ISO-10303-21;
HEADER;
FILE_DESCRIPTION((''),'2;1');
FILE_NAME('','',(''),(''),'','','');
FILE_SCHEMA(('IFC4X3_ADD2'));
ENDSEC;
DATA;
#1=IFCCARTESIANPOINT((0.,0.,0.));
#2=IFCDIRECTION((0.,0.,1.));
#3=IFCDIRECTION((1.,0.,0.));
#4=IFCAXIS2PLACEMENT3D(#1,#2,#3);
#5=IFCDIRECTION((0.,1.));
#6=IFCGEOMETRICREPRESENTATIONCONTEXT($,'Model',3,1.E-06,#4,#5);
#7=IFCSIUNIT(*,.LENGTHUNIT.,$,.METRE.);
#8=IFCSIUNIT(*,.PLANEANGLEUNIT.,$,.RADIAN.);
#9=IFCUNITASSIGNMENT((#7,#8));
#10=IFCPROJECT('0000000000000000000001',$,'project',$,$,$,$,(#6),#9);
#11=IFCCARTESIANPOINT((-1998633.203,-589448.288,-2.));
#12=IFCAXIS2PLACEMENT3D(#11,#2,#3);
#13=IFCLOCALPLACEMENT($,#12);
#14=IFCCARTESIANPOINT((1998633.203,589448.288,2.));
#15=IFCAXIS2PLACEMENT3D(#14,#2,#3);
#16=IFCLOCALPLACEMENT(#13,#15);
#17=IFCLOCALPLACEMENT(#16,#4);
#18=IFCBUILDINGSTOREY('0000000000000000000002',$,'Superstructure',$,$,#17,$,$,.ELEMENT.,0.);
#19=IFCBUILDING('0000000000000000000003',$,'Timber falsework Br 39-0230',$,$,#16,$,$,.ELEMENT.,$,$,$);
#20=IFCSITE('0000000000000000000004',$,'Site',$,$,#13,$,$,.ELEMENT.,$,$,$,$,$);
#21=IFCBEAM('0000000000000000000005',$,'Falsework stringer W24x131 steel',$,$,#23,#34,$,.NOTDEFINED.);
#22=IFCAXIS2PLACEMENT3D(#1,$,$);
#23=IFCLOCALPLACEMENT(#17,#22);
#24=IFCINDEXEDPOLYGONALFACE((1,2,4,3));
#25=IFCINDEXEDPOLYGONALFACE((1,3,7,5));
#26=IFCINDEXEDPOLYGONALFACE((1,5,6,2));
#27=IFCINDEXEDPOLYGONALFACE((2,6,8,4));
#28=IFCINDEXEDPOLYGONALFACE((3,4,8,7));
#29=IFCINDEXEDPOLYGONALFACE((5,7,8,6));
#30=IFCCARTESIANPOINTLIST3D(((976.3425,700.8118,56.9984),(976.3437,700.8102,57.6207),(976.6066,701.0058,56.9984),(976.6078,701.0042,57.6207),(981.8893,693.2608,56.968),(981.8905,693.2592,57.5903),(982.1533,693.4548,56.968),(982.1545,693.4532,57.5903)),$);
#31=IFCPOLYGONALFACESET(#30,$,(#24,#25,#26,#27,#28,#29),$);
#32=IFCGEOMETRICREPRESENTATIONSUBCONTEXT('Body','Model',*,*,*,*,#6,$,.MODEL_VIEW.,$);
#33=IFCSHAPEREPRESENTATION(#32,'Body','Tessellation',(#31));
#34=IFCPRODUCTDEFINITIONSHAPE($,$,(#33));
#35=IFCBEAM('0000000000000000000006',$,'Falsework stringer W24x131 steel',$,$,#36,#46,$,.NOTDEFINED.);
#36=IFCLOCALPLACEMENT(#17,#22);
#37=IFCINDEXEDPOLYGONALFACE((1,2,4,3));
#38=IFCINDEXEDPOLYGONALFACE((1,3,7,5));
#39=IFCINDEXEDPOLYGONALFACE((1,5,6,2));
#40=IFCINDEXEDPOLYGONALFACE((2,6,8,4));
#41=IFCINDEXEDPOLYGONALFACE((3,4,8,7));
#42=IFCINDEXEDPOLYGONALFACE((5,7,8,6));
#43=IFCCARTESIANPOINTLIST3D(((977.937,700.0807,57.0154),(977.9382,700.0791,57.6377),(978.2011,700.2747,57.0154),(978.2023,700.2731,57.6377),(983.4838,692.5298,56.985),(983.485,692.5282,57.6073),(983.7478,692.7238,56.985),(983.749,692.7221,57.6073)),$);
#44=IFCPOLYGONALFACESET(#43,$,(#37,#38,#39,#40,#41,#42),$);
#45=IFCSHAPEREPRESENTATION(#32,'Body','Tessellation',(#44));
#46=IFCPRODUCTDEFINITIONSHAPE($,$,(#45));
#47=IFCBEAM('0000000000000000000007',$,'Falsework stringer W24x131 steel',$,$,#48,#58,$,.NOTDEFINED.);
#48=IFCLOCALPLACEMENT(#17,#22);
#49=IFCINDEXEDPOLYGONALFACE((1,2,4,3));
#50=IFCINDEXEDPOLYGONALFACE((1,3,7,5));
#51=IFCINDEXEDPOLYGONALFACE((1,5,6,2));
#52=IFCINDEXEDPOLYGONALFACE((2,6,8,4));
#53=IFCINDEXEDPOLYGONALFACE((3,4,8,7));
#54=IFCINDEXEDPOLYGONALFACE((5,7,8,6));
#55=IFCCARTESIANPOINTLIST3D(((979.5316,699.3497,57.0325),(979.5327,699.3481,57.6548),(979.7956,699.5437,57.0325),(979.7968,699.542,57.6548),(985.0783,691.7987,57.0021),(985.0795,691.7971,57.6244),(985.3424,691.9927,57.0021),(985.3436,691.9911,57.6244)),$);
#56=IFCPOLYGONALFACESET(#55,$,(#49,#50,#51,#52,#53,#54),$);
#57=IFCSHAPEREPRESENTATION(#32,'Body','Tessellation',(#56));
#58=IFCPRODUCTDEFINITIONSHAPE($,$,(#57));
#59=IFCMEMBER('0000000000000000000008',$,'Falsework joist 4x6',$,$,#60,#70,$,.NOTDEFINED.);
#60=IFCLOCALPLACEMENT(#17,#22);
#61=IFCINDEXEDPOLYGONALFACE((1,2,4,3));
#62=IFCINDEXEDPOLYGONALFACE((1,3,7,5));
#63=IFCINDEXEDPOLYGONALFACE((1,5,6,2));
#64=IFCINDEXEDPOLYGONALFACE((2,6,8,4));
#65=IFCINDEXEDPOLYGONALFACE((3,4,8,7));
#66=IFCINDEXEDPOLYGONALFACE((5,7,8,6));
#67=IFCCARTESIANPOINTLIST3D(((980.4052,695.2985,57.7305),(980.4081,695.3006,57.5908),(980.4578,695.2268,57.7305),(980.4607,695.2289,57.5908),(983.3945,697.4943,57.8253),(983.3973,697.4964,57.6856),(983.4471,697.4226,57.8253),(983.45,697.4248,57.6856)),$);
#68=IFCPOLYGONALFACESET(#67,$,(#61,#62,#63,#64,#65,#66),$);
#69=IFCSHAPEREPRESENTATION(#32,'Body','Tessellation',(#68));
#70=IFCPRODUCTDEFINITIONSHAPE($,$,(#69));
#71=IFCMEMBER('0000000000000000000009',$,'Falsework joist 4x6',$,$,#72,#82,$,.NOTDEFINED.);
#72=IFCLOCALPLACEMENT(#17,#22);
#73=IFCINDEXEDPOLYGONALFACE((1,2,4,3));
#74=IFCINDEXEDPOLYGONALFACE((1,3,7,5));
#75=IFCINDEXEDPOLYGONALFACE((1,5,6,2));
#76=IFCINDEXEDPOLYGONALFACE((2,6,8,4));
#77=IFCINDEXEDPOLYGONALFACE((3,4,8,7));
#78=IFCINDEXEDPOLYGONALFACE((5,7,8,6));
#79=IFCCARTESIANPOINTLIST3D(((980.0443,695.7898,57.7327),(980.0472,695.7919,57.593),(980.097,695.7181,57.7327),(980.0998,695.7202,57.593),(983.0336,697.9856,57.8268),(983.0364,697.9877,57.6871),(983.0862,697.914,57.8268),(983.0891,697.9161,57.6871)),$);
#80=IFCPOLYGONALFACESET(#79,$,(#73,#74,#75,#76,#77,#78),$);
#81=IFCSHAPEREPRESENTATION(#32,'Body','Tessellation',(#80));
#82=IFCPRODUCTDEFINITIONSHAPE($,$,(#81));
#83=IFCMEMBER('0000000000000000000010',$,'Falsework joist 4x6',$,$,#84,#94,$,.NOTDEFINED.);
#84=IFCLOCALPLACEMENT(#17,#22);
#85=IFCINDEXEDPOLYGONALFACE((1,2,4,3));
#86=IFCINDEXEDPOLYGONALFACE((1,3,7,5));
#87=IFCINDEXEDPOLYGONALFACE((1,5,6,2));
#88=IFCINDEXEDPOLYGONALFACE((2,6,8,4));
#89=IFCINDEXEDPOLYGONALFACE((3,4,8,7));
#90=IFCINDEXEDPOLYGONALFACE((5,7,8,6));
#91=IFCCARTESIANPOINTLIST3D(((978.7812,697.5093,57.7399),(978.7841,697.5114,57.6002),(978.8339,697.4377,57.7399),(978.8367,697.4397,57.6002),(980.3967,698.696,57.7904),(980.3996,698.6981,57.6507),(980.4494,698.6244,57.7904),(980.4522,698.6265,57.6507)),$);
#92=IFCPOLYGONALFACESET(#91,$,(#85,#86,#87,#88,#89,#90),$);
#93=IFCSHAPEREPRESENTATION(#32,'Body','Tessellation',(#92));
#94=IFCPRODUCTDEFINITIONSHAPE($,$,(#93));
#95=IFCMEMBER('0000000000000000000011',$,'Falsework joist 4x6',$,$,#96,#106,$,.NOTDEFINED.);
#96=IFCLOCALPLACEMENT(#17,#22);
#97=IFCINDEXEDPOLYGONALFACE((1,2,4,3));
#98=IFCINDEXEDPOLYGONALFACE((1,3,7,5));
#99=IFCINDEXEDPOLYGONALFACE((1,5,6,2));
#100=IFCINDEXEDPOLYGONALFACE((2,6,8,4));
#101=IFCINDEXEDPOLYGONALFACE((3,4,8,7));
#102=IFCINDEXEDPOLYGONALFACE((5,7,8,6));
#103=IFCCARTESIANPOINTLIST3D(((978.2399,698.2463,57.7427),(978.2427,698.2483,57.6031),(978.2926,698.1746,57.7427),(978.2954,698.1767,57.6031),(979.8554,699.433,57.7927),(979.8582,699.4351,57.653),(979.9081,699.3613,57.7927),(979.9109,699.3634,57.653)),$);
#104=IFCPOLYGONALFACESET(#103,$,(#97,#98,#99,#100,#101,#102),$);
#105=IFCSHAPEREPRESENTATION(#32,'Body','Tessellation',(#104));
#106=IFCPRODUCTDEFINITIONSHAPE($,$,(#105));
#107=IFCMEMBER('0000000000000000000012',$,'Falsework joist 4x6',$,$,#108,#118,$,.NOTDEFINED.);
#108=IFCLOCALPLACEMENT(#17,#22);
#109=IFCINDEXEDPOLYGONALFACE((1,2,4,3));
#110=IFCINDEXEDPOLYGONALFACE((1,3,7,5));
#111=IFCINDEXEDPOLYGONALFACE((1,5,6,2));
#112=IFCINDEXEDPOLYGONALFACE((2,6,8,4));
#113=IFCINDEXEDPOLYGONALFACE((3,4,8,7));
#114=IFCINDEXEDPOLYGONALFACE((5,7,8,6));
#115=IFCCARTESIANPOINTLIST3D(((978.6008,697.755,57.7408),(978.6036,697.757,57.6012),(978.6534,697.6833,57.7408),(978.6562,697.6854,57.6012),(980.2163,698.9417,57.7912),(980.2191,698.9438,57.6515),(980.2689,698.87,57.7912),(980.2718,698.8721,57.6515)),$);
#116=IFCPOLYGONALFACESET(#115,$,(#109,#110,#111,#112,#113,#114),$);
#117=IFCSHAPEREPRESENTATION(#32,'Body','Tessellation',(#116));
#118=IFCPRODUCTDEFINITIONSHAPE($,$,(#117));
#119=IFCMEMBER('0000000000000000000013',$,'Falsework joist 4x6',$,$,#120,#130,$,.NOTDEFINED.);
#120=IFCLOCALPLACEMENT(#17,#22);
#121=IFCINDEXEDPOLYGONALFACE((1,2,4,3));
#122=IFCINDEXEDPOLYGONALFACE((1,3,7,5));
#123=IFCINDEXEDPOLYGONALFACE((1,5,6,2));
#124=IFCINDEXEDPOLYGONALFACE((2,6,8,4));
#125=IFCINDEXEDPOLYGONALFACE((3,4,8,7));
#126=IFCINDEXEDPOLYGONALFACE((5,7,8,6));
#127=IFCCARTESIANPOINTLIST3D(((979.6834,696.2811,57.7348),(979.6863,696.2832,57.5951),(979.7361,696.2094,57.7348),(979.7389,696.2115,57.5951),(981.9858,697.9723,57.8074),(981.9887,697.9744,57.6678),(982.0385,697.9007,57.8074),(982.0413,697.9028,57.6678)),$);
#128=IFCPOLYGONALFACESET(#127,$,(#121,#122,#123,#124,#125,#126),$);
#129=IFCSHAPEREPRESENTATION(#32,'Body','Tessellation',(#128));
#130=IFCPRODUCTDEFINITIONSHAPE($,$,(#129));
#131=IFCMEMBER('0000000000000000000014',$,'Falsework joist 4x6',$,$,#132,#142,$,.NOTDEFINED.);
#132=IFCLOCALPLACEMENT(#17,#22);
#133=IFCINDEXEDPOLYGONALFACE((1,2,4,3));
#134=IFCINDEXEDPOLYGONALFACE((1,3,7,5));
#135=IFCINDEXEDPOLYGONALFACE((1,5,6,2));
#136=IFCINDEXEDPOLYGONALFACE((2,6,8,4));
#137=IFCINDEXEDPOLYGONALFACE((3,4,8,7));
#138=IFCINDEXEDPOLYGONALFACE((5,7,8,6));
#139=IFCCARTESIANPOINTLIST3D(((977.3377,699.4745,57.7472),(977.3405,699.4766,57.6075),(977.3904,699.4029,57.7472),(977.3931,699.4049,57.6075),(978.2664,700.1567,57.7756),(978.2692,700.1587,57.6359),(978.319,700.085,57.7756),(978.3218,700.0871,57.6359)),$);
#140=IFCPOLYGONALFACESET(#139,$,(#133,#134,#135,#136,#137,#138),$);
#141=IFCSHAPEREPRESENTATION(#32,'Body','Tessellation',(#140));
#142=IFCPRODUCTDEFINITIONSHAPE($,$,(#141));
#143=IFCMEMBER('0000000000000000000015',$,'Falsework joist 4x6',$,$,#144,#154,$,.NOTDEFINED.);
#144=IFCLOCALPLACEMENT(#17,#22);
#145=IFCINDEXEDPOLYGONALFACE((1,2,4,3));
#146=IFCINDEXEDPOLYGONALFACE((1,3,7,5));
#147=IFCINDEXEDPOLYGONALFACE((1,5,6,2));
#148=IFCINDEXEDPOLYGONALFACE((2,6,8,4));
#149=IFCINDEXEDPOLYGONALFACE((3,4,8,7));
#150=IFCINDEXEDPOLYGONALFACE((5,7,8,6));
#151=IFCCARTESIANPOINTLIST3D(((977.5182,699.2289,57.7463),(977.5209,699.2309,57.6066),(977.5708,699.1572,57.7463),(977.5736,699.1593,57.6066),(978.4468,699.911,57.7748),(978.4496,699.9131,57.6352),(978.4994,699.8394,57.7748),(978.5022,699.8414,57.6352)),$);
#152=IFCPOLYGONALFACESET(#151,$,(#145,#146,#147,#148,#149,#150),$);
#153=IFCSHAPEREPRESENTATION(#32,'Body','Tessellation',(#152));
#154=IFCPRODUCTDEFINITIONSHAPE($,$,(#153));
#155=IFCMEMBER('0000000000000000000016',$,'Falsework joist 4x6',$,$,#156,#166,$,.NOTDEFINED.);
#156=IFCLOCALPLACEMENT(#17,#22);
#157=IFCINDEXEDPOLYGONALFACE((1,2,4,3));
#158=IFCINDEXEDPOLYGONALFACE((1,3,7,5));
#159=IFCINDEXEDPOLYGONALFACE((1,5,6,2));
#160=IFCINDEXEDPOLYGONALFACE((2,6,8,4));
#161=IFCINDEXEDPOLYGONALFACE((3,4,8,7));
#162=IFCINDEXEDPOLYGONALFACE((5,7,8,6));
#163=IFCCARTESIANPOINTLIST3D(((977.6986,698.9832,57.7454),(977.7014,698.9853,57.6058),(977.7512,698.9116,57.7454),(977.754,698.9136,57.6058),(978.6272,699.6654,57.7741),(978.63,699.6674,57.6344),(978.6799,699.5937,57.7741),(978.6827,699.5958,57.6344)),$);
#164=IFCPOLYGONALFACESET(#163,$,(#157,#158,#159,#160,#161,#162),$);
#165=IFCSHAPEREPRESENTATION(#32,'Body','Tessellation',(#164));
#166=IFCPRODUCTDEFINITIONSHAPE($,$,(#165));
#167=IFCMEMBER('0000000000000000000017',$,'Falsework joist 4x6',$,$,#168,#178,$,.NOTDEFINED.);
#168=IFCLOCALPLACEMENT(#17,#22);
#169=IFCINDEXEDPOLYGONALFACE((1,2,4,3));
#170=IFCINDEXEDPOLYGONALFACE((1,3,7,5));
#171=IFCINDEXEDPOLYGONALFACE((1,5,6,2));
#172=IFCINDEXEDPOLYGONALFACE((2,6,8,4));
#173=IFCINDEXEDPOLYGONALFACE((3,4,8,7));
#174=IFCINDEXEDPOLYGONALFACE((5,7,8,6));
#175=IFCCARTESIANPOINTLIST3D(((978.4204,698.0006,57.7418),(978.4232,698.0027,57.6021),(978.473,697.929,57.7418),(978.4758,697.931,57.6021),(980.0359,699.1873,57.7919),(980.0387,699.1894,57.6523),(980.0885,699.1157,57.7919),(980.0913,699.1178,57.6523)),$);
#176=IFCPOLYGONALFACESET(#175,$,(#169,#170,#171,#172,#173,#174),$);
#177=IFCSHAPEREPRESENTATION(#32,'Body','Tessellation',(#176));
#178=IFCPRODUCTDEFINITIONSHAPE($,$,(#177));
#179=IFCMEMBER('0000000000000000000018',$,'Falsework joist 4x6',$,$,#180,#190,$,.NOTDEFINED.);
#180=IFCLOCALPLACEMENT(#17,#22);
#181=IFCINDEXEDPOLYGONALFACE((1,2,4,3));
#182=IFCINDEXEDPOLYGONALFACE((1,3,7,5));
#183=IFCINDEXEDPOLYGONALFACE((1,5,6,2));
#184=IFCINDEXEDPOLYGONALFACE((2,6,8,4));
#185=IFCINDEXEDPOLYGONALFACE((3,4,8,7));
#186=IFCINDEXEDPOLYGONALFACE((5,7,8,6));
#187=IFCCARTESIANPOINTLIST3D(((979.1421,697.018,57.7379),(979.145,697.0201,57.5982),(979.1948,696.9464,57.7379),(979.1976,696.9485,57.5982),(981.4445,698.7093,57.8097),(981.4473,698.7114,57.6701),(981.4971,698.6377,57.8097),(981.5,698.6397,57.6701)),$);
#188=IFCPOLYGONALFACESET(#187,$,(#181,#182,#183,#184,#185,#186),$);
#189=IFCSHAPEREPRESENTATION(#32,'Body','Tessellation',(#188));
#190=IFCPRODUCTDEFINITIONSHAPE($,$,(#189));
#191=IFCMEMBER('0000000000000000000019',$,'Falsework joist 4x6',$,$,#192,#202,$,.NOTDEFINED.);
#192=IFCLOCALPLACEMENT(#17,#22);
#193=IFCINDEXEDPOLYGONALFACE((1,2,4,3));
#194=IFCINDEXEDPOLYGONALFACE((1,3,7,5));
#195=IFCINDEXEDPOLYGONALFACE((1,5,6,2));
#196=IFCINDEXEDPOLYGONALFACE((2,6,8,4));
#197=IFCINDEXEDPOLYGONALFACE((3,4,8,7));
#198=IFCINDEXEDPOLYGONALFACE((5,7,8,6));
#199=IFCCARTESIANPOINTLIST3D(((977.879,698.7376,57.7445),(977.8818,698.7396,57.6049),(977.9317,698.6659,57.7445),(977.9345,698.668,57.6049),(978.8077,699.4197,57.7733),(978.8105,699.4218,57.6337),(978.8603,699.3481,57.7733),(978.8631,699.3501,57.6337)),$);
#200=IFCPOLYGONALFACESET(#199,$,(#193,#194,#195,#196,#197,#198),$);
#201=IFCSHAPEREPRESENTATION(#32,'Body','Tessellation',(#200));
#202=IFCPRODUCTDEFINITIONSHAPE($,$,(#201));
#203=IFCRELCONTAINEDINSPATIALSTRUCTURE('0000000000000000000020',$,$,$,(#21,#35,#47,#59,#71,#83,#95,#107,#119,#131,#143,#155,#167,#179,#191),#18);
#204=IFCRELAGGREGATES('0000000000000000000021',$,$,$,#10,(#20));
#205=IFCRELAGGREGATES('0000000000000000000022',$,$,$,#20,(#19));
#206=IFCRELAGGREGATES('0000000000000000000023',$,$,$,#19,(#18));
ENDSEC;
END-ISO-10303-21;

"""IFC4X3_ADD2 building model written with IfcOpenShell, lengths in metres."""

from ifc_helpers import new_model, si_unit, direction, frame, frame_2d, origin, origin_with_axes, place, context, subcontext, project, spatial, rectangle, extrude, element, save


model = new_model("IFC4X3_ADD2")

# Units and contexts
model_context = context("Model", 3, precision=1e-06, world=origin_with_axes(), true_north=direction((0.0, 1.0)))
body_context = subcontext(model_context, "Body", "Model", "MODEL_VIEW")
ifc_project = project(units=[si_unit("LENGTHUNIT", "METRE"), si_unit("PLANEANGLEUNIT", "RADIAN")], contexts=[model_context])

# Site, building, storey
site_placement = place(None, frame((-1998633.203, -589448.288, -2.0), z_axis=(0.0, 0.0, 1.0), x_axis=(1.0, 0.0, 0.0)))
site = spatial("IfcSite", under=ifc_project, at=site_placement, Name="Site", CompositionType="ELEMENT")
building_placement = place(site_placement, frame((1998633.203, 589448.288, 2.0), z_axis=(0.0, 0.0, 1.0), x_axis=(1.0, 0.0, 0.0)))
building = spatial("IfcBuilding", under=site, at=building_placement, Name="Timber falsework Br 39-0230", CompositionType="ELEMENT")
storey_placement = place(building_placement, origin_with_axes())
storey = spatial("IfcBuildingStorey", under=building, at=storey_placement, Name="Superstructure", CompositionType="ELEMENT", Elevation=0.0)

# Beams
beam_placement = place(storey_placement, frame((976.4746, 700.9088, 56.9984), z_axis=(0.59201, -0.805924, -0.003244), x_axis=(0.805928, 0.592013, 0.0)))
element("IfcBeam", 1, at=beam_placement, inside=storey, Name="Falsework stringer W24x131 steel", PredefinedType="NOTDEFINED", context=body_context, shape_type="SweptSolid", body=[
    extrude(rectangle(XDim=0.3277, YDim=0.6223, at=frame_2d((0.0, 0.3111))), origin(), (0.0, 0.0, 1.0), 9.3693),
])
for number, where, z_axis, x_axis, name in (
    (2, (978.0691, 700.1777, 57.0154), (0.59201, -0.805924, -0.003244), (0.805928, 0.592013, 0.0), "Falsework stringer W24x131 steel"),
    (3, (979.6636, 699.4467, 57.0325), (0.59201, -0.805924, -0.003244), (0.805928, 0.592013, 0.0), "Falsework stringer W24x131 steel"),
):
    element("IfcBeam", number, at=place(storey_placement, frame(where, z_axis=z_axis, x_axis=x_axis)), inside=storey, Name=name, PredefinedType="NOTDEFINED", context=body_context, shape_type="SweptSolid", body=[
        extrude(rectangle(XDim=0.3277, YDim=0.6223, at=frame_2d((0.0, 0.3111))), origin(), (0.0, 0.0, 1.0), 9.3693),
    ])

# Members
member_1_placement = place(storey_placement, frame((980.4344, 695.2648, 57.5908), z_axis=(0.805665, 0.59182, 0.02556), x_axis=(-0.592013, 0.805928, 0.0)))
element("IfcMember", 4, at=member_1_placement, inside=storey, Name="Falsework joist 4x6", PredefinedType="NOTDEFINED", context=body_context, shape_type="SweptSolid", body=[
    extrude(rectangle(XDim=0.0889, YDim=0.1397, at=frame_2d((0.0, 0.0698))), origin(), (0.0, 0.0, 1.0), 3.7103),
])
member_2_placement = place(storey_placement, frame((980.0735, 695.756, 57.593), z_axis=(0.805669, 0.591823, 0.025371), x_axis=(-0.592013, 0.805928, 0.0)))
element("IfcMember", 5, at=member_2_placement, inside=storey, Name="Falsework joist 4x6", PredefinedType="NOTDEFINED", context=body_context, shape_type="SweptSolid", body=[
    extrude(rectangle(XDim=0.0889, YDim=0.1397, at=frame_2d((0.0, 0.0698))), origin(), (0.0, 0.0, 1.0), 3.7103),
])
member_3_placement = place(storey_placement, frame((978.8104, 697.4756, 57.6002), z_axis=(0.805673, 0.591825, 0.025184), x_axis=(-0.592013, 0.805928, 0.0)))
element("IfcMember", 6, at=member_3_placement, inside=storey, Name="Falsework joist 4x6", PredefinedType="NOTDEFINED", context=body_context, shape_type="SweptSolid", body=[
    extrude(rectangle(XDim=0.0889, YDim=0.1397, at=frame_2d((0.0, 0.0698))), origin(), (0.0, 0.0, 1.0), 2.0052),
])
member_4_placement = place(storey_placement, frame((978.269, 698.2125, 57.6031), z_axis=(0.805678, 0.59183, 0.024901), x_axis=(-0.592013, 0.805928, 0.0)))
element("IfcMember", 7, at=member_4_placement, inside=storey, Name="Falsework joist 4x6", PredefinedType="NOTDEFINED", context=body_context, shape_type="SweptSolid", body=[
    extrude(rectangle(XDim=0.0889, YDim=0.1397, at=frame_2d((0.0, 0.0698))), origin(), (0.0, 0.0, 1.0), 2.0052),
])
member_5_placement = place(storey_placement, frame((978.6299, 697.7212, 57.6012), z_axis=(0.805675, 0.591827, 0.02509), x_axis=(-0.592013, 0.805928, 0.0)))
element("IfcMember", 8, at=member_5_placement, inside=storey, Name="Falsework joist 4x6", PredefinedType="NOTDEFINED", context=body_context, shape_type="SweptSolid", body=[
    extrude(rectangle(XDim=0.0889, YDim=0.1397, at=frame_2d((0.0, 0.0698))), origin(), (0.0, 0.0, 1.0), 2.0052),
])
member_6_placement = place(storey_placement, frame((979.7126, 696.2473, 57.5951), z_axis=(0.805668, 0.591822, 0.02542), x_axis=(-0.592013, 0.805928, 0.0)))
element("IfcMember", 9, at=member_6_placement, inside=storey, Name="Falsework joist 4x6", PredefinedType="NOTDEFINED", context=body_context, shape_type="SweptSolid", body=[
    extrude(rectangle(XDim=0.0889, YDim=0.1397, at=frame_2d((0.0, 0.0698))), origin(), (0.0, 0.0, 1.0), 2.8577),
])
member_7_placement = place(storey_placement, frame((977.3668, 699.4407, 57.6075), z_axis=(0.805683, 0.591833, 0.024665), x_axis=(-0.592013, 0.805928, 0.0)))
element("IfcMember", 10, at=member_7_placement, inside=storey, Name="Falsework joist 4x6", PredefinedType="NOTDEFINED", context=body_context, shape_type="SweptSolid", body=[
    extrude(rectangle(XDim=0.0889, YDim=0.1397, at=frame_2d((0.0, 0.0698))), origin(), (0.0, 0.0, 1.0), 1.1526),
])
member_8_placement = place(storey_placement, frame((977.5473, 699.1951, 57.6066), z_axis=(0.805681, 0.591832, 0.02476), x_axis=(-0.592013, 0.805928, 0.0)))
element("IfcMember", 11, at=member_8_placement, inside=storey, Name="Falsework joist 4x6", PredefinedType="NOTDEFINED", context=body_context, shape_type="SweptSolid", body=[
    extrude(rectangle(XDim=0.0889, YDim=0.1397, at=frame_2d((0.0, 0.0698))), origin(), (0.0, 0.0, 1.0), 1.1526),
])
member_9_placement = place(storey_placement, frame((977.7277, 698.9495, 57.6058), z_axis=(0.805679, 0.59183, 0.024855), x_axis=(-0.592013, 0.805928, 0.0)))
element("IfcMember", 12, at=member_9_placement, inside=storey, Name="Falsework joist 4x6", PredefinedType="NOTDEFINED", context=body_context, shape_type="SweptSolid", body=[
    extrude(rectangle(XDim=0.0889, YDim=0.1397, at=frame_2d((0.0, 0.0698))), origin(), (0.0, 0.0, 1.0), 1.1526),
])
member_10_placement = place(storey_placement, frame((978.4495, 697.9669, 57.6021), z_axis=(0.805676, 0.591828, 0.024995), x_axis=(-0.592013, 0.805928, 0.0)))
element("IfcMember", 13, at=member_10_placement, inside=storey, Name="Falsework joist 4x6", PredefinedType="NOTDEFINED", context=body_context, shape_type="SweptSolid", body=[
    extrude(rectangle(XDim=0.0889, YDim=0.1397, at=frame_2d((0.0, 0.0698))), origin(), (0.0, 0.0, 1.0), 2.0052),
])
member_11_placement = place(storey_placement, frame((979.1713, 696.9843, 57.5982), z_axis=(0.805674, 0.591826, 0.025136), x_axis=(-0.592013, 0.805928, 0.0)))
element("IfcMember", 14, at=member_11_placement, inside=storey, Name="Falsework joist 4x6", PredefinedType="NOTDEFINED", context=body_context, shape_type="SweptSolid", body=[
    extrude(rectangle(XDim=0.0889, YDim=0.1397, at=frame_2d((0.0, 0.0698))), origin(), (0.0, 0.0, 1.0), 2.8577),
])
member_12_placement = place(storey_placement, frame((977.9082, 698.7038, 57.6049), z_axis=(0.805677, 0.591829, 0.024949), x_axis=(-0.592013, 0.805928, 0.0)))
element("IfcMember", 15, at=member_12_placement, inside=storey, Name="Falsework joist 4x6", PredefinedType="NOTDEFINED", context=body_context, shape_type="SweptSolid", body=[
    extrude(rectangle(XDim=0.0889, YDim=0.1397, at=frame_2d((0.0, 0.0698))), origin(), (0.0, 0.0, 1.0), 1.1526),
])

save(model, "model.ifc")
